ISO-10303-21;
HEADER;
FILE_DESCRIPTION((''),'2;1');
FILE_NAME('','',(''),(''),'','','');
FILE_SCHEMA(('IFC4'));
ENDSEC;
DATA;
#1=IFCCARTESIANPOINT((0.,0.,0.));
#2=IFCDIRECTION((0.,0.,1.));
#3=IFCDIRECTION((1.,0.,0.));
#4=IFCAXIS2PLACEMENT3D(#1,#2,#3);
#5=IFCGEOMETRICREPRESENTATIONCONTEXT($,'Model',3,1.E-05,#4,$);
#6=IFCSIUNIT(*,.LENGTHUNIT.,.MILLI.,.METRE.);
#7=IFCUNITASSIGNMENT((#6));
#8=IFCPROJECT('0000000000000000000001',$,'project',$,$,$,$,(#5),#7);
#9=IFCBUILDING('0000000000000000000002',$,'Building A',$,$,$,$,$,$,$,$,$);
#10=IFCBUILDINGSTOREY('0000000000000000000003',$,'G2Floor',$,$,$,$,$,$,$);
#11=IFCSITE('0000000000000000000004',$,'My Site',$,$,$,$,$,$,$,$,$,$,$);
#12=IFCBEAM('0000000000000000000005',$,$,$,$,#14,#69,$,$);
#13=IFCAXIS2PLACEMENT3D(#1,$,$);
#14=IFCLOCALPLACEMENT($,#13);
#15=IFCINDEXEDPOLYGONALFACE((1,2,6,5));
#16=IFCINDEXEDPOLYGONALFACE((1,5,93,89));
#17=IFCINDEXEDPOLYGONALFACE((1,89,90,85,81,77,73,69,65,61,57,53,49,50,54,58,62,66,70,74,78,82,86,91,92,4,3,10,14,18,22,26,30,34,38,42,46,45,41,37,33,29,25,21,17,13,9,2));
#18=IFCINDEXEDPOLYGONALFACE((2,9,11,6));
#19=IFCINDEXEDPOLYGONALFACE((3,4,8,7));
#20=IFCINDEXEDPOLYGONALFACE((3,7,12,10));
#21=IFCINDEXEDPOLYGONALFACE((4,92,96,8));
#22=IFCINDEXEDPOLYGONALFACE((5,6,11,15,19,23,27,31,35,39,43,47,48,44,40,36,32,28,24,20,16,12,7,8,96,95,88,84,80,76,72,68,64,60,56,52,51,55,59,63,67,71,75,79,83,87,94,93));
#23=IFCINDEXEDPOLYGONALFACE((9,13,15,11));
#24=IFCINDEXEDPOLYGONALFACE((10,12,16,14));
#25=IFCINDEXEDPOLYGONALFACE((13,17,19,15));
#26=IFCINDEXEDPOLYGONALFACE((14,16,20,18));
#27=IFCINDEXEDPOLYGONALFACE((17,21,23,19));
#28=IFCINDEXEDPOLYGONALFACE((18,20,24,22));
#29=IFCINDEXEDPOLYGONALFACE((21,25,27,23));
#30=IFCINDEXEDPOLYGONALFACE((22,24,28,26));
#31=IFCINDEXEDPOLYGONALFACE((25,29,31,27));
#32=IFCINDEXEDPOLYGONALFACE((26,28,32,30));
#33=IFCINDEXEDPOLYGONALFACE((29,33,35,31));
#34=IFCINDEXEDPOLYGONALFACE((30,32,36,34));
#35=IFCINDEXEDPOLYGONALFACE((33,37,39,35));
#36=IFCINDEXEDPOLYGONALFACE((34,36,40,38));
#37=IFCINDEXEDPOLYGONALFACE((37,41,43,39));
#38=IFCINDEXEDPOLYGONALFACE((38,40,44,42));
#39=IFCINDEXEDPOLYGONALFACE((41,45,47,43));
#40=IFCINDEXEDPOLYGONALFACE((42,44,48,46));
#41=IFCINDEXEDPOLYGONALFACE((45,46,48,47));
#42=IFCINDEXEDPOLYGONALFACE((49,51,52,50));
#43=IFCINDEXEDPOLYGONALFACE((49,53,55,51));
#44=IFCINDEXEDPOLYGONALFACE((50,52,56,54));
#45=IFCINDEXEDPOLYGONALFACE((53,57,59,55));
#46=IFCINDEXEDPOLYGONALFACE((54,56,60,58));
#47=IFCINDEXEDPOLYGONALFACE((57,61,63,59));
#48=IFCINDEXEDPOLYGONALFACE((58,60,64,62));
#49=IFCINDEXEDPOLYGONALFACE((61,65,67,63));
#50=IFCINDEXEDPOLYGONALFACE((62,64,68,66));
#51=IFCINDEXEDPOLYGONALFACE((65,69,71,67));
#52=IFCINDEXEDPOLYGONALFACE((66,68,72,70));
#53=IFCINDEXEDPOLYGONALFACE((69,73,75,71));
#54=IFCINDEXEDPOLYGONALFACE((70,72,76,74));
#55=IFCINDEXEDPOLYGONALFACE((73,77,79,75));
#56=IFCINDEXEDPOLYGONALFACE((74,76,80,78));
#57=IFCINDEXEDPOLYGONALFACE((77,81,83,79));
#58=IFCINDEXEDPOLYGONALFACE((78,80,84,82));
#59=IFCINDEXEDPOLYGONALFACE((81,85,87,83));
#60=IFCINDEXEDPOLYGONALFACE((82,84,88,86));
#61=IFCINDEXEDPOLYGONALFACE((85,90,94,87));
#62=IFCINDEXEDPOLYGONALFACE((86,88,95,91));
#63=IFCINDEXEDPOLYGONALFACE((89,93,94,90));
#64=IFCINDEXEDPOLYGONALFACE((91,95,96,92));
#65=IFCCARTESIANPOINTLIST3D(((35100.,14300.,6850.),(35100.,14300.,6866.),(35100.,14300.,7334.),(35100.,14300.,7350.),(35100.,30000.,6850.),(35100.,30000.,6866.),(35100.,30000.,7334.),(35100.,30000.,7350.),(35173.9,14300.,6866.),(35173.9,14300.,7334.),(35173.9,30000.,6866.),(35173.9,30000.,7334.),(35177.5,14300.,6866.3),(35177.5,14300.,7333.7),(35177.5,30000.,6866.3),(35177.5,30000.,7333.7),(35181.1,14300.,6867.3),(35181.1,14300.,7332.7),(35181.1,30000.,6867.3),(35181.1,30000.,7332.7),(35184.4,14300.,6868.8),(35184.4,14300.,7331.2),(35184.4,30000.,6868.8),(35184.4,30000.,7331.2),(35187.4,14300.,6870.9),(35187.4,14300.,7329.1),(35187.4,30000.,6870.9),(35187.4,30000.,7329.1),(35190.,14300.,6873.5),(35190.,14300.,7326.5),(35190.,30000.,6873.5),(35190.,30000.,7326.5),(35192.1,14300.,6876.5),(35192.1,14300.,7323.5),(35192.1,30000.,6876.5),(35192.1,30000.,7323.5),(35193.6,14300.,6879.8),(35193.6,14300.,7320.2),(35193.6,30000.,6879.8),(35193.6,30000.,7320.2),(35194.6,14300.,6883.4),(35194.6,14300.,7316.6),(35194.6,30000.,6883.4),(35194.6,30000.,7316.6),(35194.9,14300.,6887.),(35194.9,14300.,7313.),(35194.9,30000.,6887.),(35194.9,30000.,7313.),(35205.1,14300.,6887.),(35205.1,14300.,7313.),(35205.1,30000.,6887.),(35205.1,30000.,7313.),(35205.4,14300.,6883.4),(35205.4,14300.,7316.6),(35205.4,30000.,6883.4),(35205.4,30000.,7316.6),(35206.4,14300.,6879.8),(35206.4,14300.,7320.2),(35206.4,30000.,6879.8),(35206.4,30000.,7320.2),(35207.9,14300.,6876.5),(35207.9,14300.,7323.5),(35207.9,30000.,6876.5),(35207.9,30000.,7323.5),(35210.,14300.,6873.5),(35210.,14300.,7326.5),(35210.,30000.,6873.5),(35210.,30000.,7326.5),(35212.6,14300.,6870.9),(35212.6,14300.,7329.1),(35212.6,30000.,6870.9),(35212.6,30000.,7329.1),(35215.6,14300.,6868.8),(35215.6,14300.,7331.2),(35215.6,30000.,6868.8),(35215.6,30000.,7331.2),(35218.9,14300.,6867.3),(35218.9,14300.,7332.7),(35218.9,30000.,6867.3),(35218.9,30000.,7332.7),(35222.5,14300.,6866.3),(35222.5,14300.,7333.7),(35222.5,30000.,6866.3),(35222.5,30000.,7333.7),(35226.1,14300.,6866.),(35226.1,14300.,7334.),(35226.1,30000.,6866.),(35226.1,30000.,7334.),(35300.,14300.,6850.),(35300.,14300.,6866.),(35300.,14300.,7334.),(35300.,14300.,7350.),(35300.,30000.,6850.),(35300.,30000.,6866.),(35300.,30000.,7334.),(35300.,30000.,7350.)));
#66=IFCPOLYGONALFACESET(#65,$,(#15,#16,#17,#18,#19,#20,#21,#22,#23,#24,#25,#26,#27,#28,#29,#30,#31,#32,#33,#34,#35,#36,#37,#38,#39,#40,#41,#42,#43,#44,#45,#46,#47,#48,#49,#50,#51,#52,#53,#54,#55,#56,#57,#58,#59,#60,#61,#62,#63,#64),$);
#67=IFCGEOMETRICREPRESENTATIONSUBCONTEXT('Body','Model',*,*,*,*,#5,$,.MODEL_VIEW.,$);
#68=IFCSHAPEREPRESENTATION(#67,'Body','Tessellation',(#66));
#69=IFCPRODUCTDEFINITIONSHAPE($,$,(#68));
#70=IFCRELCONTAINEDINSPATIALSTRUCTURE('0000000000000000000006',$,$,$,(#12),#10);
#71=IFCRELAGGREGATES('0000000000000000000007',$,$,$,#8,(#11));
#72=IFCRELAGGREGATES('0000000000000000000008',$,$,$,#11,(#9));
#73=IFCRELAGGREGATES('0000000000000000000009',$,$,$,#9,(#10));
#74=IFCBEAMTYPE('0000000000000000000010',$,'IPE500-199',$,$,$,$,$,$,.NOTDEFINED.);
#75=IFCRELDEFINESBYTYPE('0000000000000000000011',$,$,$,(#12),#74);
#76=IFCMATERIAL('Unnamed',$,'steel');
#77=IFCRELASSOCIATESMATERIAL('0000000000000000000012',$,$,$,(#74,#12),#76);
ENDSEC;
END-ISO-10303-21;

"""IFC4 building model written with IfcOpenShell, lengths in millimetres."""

from ifc_helpers import new_model, si_unit, frame, origin_with_axes, place, context, subcontext, project, spatial, polyline, outline, extrude, material, material_profile, profile_set, profile_usage, type_object, element, save


model = new_model("IFC4")

# Units and contexts
model_context = context("Model", 3, precision=1e-05, world=origin_with_axes())
body_context = subcontext(model_context, "Body", "Model", "MODEL_VIEW")
ifc_project = project(units=[si_unit("LENGTHUNIT", "METRE", prefix="MILLI")], contexts=[model_context])

# Site, building, storey
site = spatial("IfcSite", under=ifc_project, Name="My Site")
building = spatial("IfcBuilding", under=site, Name="Building A")
storey = spatial("IfcBuildingStorey", under=building, Name="G2Floor")

# Beam
ifc_material_1 = material(Name="Unnamed", Category="steel")
ifc_material_profile_1 = material_profile(ifc_material_1, outline(polyline([(100.0, -250.0), (100.0, -234.0), (100.0, -234.0), (26.1, -234.0), (26.1, -234.0), (22.5, -233.7), (22.5, -233.7), (18.9, -232.7), (18.9, -232.7), (15.6, -231.2), (15.6, -231.2), (12.6, -229.1), (12.6, -229.1), (10.0, -226.5), (10.0, -226.5), (7.9, -223.5), (7.9, -223.5), (6.4, -220.2), (6.4, -220.2), (5.4, -216.6), (5.4, -216.6), (5.1, -213.0), (5.1, -213.0), (5.1, 213.0), (5.1, 213.0), (5.4, 216.6), (5.4, 216.6), (6.4, 220.2), (6.4, 220.2), (7.9, 223.5), (7.9, 223.5), (10.0, 226.5), (10.0, 226.5), (12.6, 229.1), (12.6, 229.1), (15.6, 231.2), (15.6, 231.2), (18.9, 232.7), (18.9, 232.7), (22.5, 233.7), (22.5, 233.7), (26.1, 234.0), (26.1, 234.0), (100.0, 234.0), (100.0, 234.0), (100.0, 250.0), (100.0, 250.0), (-100.0, 250.0), (-100.0, 250.0), (-100.0, 234.0), (-100.0, 234.0), (-26.1, 234.0), (-26.1, 234.0), (-22.5, 233.7), (-22.5, 233.7), (-18.9, 232.7), (-18.9, 232.7), (-15.6, 231.2), (-15.6, 231.2), (-12.6, 229.1), (-12.6, 229.1), (-10.0, 226.5), (-10.0, 226.5), (-7.9, 223.5), (-7.9, 223.5), (-6.4, 220.2), (-6.4, 220.2), (-5.4, 216.6), (-5.4, 216.6), (-5.1, 213.0), (-5.1, 213.0), (-5.1, -213.0), (-5.1, -213.0), (-5.4, -216.6), (-5.4, -216.6), (-6.4, -220.2), (-6.4, -220.2), (-7.9, -223.5), (-7.9, -223.5), (-10.0, -226.5), (-10.0, -226.5), (-12.6, -229.1), (-12.6, -229.1), (-15.6, -231.2), (-15.6, -231.2), (-18.9, -232.7), (-18.9, -232.7), (-22.5, -233.7), (-22.5, -233.7), (-26.1, -234.0), (-26.1, -234.0), (-100.0, -234.0), (-100.0, -234.0), (-100.0, -250.0), (-100.0, -250.0), (100.0, -250.0)])))
ifc_profile_set_1 = profile_set([ifc_material_profile_1], Name="IPE500-199")
ifc_profile_usage_1 = profile_usage(ifc_profile_set_1)
beam_type_1 = type_object("IfcBeamType", Name="IPE500-199", PredefinedType="NOTDEFINED", material=ifc_profile_set_1)
beam_1_placement = place(None, frame((35200.0, 14300.0, 7100.0), z_axis=(0.0, 1.0, 0.0), x_axis=(1.0, 0.0, 0.0)))
element("IfcBeam", 1, at=beam_1_placement, inside=storey, type_object=beam_type_1, material=ifc_profile_usage_1, context=body_context, shape_type="SweptSolid", body=[
    extrude(outline(polyline([(100.0, -250.0), (100.0, -234.0), (100.0, -234.0), (26.1, -234.0), (26.1, -234.0), (22.5, -233.7), (22.5, -233.7), (18.9, -232.7), (18.9, -232.7), (15.6, -231.2), (15.6, -231.2), (12.6, -229.1), (12.6, -229.1), (10.0, -226.5), (10.0, -226.5), (7.9, -223.5), (7.9, -223.5), (6.4, -220.2), (6.4, -220.2), (5.4, -216.6), (5.4, -216.6), (5.1, -213.0), (5.1, -213.0), (5.1, 213.0), (5.1, 213.0), (5.4, 216.6), (5.4, 216.6), (6.4, 220.2), (6.4, 220.2), (7.9, 223.5), (7.9, 223.5), (10.0, 226.5), (10.0, 226.5), (12.6, 229.1), (12.6, 229.1), (15.6, 231.2), (15.6, 231.2), (18.9, 232.7), (18.9, 232.7), (22.5, 233.7), (22.5, 233.7), (26.1, 234.0), (26.1, 234.0), (100.0, 234.0), (100.0, 234.0), (100.0, 250.0), (100.0, 250.0), (-100.0, 250.0), (-100.0, 250.0), (-100.0, 234.0), (-100.0, 234.0), (-26.1, 234.0), (-26.1, 234.0), (-22.5, 233.7), (-22.5, 233.7), (-18.9, 232.7), (-18.9, 232.7), (-15.6, 231.2), (-15.6, 231.2), (-12.6, 229.1), (-12.6, 229.1), (-10.0, 226.5), (-10.0, 226.5), (-7.9, 223.5), (-7.9, 223.5), (-6.4, 220.2), (-6.4, 220.2), (-5.4, 216.6), (-5.4, 216.6), (-5.1, 213.0), (-5.1, 213.0), (-5.1, -213.0), (-5.1, -213.0), (-5.4, -216.6), (-5.4, -216.6), (-6.4, -220.2), (-6.4, -220.2), (-7.9, -223.5), (-7.9, -223.5), (-10.0, -226.5), (-10.0, -226.5), (-12.6, -229.1), (-12.6, -229.1), (-15.6, -231.2), (-15.6, -231.2), (-18.9, -232.7), (-18.9, -232.7), (-22.5, -233.7), (-22.5, -233.7), (-26.1, -234.0), (-26.1, -234.0), (-100.0, -234.0), (-100.0, -234.0), (-100.0, -250.0), (-100.0, -250.0), (100.0, -250.0)])), origin_with_axes(), (0.0, 0.0, 1.0), 15700.0),
])

save(model, "model.ifc")
